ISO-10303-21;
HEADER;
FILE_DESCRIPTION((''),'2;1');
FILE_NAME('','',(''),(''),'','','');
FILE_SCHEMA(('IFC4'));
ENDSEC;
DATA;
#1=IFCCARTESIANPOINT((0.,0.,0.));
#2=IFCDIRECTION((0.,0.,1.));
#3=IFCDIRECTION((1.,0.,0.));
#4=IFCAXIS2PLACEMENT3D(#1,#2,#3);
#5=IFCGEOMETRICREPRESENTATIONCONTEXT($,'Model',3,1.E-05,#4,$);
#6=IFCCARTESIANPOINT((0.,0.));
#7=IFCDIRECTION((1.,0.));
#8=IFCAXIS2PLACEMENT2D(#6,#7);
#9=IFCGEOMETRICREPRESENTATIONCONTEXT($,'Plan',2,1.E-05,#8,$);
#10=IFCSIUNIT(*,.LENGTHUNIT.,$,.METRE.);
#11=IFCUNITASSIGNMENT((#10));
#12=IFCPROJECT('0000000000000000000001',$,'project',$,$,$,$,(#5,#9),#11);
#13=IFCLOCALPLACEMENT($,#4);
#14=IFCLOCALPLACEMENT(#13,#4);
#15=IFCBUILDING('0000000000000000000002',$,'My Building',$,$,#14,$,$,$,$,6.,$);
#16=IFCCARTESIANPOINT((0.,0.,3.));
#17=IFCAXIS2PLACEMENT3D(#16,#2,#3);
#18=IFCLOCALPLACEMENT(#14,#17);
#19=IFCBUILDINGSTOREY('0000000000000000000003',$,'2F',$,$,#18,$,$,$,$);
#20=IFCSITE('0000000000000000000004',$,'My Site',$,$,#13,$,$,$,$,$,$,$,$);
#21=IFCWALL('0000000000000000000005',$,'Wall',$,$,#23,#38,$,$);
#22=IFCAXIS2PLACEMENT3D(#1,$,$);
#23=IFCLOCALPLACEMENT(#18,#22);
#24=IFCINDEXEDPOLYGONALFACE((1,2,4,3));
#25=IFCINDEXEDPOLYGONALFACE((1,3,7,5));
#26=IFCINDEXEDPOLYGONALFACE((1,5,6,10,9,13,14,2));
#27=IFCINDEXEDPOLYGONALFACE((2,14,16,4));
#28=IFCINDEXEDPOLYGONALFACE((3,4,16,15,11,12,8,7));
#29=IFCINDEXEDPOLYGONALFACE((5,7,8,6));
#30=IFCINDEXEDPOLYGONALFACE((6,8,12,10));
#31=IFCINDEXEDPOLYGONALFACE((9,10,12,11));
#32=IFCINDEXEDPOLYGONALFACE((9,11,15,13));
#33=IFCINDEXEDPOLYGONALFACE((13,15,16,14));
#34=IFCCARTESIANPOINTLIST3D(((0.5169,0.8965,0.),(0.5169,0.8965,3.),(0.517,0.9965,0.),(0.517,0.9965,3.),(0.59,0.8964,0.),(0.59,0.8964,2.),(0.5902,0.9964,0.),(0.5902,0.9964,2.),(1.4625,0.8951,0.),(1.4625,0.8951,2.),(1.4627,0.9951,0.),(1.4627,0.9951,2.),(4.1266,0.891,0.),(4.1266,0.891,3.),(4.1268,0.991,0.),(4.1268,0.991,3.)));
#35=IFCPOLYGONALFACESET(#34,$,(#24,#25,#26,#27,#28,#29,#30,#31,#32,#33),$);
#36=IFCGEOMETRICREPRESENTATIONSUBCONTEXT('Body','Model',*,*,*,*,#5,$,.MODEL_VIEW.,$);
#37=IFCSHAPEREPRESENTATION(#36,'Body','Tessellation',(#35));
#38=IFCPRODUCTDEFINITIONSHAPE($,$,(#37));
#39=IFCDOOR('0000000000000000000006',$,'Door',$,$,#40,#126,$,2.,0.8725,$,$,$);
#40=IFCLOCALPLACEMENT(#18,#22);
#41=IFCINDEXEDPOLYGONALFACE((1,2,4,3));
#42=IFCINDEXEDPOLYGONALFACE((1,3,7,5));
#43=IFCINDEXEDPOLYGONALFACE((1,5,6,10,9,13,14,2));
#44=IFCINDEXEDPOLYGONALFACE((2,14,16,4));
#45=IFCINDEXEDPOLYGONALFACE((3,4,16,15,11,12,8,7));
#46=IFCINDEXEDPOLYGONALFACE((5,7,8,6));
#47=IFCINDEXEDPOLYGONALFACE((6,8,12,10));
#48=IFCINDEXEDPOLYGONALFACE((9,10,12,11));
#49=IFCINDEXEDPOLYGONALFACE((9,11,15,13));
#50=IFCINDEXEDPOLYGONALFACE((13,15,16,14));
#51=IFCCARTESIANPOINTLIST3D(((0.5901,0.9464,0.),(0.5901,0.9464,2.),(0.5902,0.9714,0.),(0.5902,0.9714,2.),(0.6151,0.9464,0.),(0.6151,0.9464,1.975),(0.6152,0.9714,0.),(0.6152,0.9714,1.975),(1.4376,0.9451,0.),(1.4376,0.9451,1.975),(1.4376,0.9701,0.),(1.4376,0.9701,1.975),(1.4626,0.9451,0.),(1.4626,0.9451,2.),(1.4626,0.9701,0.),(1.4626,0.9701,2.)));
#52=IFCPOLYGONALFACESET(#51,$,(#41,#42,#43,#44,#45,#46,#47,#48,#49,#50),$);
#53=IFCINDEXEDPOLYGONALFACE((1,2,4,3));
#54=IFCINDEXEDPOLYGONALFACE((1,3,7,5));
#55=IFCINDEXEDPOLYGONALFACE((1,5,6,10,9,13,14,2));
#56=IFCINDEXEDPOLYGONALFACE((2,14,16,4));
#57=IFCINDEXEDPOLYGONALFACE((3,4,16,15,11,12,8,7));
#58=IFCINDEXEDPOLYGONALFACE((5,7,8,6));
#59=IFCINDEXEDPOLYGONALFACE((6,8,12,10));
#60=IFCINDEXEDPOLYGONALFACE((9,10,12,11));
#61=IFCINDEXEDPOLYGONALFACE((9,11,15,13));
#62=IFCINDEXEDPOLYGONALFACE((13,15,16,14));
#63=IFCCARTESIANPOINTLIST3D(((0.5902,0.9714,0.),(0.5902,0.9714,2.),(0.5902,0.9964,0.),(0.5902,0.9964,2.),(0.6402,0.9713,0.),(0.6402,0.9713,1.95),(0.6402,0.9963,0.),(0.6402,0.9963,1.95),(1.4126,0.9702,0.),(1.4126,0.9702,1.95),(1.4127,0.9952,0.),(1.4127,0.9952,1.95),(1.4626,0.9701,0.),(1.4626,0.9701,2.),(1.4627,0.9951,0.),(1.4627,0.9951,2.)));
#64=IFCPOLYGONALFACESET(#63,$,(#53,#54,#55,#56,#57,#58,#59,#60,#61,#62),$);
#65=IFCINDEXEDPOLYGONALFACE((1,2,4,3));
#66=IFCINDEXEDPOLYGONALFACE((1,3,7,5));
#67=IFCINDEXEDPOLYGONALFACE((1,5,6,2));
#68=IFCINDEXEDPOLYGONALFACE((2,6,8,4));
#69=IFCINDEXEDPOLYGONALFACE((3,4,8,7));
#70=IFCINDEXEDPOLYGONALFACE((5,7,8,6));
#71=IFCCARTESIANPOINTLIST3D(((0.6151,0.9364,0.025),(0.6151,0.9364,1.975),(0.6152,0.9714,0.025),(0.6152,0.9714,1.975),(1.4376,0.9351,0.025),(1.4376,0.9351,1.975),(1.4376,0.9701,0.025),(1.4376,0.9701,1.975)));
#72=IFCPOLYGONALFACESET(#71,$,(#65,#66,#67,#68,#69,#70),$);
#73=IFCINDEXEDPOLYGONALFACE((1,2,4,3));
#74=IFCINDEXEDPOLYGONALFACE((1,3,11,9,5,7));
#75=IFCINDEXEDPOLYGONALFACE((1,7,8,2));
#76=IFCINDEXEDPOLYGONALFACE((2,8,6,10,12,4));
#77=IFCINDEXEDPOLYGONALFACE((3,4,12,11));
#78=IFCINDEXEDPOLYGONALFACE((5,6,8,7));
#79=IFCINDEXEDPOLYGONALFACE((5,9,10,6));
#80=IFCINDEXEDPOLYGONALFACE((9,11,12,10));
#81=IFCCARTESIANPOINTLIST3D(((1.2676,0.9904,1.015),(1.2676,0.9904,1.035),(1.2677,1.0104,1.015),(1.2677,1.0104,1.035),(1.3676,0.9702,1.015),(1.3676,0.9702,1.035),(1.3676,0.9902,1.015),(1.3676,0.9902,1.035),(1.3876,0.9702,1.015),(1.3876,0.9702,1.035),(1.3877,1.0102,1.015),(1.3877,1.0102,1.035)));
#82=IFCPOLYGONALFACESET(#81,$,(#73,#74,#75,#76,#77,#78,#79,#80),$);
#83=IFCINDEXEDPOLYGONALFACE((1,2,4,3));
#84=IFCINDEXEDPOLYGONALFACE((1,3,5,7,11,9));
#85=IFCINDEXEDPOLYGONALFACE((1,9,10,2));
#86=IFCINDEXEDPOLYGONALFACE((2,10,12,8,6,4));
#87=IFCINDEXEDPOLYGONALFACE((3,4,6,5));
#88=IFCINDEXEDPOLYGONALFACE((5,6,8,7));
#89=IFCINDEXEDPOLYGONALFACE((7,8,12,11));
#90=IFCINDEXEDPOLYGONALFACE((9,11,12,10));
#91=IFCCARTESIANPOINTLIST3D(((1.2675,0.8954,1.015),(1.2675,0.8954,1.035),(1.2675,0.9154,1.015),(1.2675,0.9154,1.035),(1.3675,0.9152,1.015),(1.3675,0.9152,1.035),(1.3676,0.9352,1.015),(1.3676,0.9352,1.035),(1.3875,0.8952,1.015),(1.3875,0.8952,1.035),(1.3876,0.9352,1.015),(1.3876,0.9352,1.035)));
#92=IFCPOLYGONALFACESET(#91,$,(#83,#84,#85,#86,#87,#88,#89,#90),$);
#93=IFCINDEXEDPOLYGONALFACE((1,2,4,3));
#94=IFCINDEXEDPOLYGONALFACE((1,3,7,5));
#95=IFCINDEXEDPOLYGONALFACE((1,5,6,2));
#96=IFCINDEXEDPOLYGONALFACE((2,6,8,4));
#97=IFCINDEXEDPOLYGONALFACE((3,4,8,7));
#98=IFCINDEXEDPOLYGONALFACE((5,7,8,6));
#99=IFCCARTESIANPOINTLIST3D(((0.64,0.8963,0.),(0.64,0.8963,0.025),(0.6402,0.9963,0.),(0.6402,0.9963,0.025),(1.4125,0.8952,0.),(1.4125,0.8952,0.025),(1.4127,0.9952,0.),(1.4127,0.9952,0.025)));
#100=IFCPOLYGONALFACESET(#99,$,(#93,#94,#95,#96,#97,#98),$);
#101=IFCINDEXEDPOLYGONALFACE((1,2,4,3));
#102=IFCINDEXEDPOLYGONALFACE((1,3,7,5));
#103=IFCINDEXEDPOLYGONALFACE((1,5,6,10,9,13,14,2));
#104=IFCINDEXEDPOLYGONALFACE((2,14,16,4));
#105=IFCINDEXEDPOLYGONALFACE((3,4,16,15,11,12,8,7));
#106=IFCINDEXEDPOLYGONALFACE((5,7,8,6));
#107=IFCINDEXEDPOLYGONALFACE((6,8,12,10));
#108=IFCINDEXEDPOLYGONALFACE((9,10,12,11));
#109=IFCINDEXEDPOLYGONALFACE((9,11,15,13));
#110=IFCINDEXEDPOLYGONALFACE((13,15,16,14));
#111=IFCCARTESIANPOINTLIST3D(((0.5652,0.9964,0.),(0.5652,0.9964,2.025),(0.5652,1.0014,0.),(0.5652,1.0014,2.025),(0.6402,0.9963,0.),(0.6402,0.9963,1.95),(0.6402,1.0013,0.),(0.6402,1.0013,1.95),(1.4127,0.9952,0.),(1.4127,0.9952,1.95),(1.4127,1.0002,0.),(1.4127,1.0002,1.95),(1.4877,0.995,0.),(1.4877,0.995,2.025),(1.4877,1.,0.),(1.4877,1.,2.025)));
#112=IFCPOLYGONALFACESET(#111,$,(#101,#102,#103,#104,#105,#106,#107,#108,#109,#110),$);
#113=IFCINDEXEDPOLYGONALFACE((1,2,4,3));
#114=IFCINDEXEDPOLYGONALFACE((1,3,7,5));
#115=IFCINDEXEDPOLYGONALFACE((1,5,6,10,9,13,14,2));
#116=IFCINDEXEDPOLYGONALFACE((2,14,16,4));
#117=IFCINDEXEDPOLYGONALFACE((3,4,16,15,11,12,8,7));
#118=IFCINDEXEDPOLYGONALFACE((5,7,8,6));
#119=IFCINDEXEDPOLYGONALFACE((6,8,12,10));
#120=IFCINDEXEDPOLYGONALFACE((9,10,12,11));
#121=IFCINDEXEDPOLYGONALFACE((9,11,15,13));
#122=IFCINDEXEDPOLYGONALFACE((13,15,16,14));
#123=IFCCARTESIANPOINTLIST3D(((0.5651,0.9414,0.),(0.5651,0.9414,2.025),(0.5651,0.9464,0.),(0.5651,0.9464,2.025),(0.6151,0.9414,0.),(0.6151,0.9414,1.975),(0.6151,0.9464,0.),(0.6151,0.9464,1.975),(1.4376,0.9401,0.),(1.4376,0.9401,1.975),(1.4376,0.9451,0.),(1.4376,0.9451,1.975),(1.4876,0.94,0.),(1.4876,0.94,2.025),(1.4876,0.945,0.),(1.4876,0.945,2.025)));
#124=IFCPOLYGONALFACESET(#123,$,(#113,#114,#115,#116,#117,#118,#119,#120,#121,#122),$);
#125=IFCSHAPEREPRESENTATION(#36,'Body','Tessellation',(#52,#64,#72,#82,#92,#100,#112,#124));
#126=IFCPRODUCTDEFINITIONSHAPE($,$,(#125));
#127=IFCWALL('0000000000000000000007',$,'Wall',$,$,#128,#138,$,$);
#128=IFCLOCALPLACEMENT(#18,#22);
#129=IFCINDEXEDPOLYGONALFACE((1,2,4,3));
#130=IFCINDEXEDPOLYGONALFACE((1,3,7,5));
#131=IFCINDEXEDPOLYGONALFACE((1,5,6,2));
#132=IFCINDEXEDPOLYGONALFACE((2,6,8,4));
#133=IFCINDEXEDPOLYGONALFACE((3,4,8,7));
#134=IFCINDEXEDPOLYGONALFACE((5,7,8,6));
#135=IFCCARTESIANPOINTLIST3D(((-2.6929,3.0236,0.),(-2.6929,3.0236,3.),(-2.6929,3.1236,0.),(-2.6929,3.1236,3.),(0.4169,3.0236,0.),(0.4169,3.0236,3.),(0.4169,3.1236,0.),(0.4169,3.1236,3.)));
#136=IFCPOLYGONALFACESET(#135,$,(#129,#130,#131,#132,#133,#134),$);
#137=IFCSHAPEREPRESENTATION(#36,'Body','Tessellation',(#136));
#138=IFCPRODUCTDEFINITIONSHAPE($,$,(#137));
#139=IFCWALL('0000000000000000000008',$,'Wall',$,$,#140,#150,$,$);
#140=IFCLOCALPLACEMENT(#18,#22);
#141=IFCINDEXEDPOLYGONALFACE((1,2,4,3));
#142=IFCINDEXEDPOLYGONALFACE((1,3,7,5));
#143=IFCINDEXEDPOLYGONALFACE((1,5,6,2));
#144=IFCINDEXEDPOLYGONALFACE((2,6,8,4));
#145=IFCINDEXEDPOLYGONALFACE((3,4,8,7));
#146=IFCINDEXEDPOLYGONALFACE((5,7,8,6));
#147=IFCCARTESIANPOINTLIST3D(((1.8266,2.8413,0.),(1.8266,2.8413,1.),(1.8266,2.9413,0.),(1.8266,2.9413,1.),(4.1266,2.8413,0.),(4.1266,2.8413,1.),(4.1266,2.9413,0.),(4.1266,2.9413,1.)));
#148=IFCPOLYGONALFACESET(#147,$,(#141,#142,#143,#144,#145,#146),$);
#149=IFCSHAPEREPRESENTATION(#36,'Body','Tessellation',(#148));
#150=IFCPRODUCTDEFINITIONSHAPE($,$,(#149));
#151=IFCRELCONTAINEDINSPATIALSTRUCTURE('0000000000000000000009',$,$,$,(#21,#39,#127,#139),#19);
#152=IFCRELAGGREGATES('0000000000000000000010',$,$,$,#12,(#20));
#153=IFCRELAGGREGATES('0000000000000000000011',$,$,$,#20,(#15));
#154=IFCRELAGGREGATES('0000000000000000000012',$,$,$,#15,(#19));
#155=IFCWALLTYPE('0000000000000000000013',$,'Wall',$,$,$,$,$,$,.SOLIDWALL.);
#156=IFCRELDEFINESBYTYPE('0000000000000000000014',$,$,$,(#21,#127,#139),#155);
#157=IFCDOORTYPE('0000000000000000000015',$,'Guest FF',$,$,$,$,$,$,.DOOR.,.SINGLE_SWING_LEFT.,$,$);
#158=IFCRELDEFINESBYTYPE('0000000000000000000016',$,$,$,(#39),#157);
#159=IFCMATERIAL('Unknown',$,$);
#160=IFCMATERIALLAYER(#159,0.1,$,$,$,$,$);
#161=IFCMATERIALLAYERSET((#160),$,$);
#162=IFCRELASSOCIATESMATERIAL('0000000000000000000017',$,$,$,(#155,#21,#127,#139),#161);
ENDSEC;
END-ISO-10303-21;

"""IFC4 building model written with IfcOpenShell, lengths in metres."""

from ifc_helpers import new_model, entity, si_unit, frame, origin_with_axes, origin_2d_with_axis, place, context, subcontext, project, spatial, line, indexed_curve, outline, extrude, shape, source, transform, mapped, material, layer, layer_set, layer_usage, type_object, type_shapes, element, fill, save


model = new_model("IFC4")

# Units and contexts
model_context = context("Model", 3, precision=1e-05, world=origin_with_axes())
plan_context = context("Plan", 2, precision=1e-05, world=origin_2d_with_axis())
body_context_1 = subcontext(model_context, "Body", "Model", "MODEL_VIEW")
body_context_2 = subcontext(plan_context, "Body", "Plan", "PLAN_VIEW")
ifc_project = project(units=[si_unit("LENGTHUNIT", "METRE")], contexts=[model_context, plan_context])

# Site, building, storey
site_placement = place(None, origin_with_axes())
site = spatial("IfcSite", under=ifc_project, at=site_placement, Name="My Site")
building_placement = place(site_placement, origin_with_axes())
building = spatial("IfcBuilding", under=site, at=building_placement, Name="My Building", ElevationOfTerrain=6.0)
storey_placement = place(building_placement, frame((0.0, 0.0, 3.0), z_axis=(0.0, 0.0, 1.0), x_axis=(1.0, 0.0, 0.0)))
storey = spatial("IfcBuildingStorey", under=building, at=storey_placement, Name="2F")

# Shared definitions
ifc_material = material(Name="Unknown")

# Shared definitions
ifc_layer_1 = layer(ifc_material, 0.1)
ifc_layer_set_1 = layer_set([ifc_layer_1])
wall_type = type_object("IfcWallType", Name="Wall", PredefinedType="SOLIDWALL", material=ifc_layer_set_1)

# Shared definitions
shared_shape_1 = source(origin_with_axes(), body_context_1, "Body", "SweptSolid", [
    extrude(outline(indexed_curve([(0.0, 0.0), (0.8725, 0.0), (0.8725, 2.0), (0.0, 2.0)], segments=[line(1, 2, 3, 4, 1)])), frame((0.0, -0.6, 0.0), z_axis=(0.0, -1.0, 0.0), x_axis=(1.0, 0.0, 0.0)), (0.0, 0.0, -1.0), 1.2),
])
door_type_1 = type_object("IfcDoorType", Name="Guest FF", OperationType="SINGLE_SWING_LEFT", PredefinedType="DOOR")
shared_shape_2 = source(origin_with_axes(), body_context_1, "Body", "SweptSolid", [
    extrude(outline(indexed_curve([(0.0, 0.0), (0.0, 2.0), (0.8725, 2.0), (0.8725, 0.0), (0.8475, 0.0), (0.8475, 1.975), (0.025, 1.975), (0.025, 0.0)], segments=[line(1, 2, 3, 4, 5, 6, 7, 8, 1)])), frame((0.0, 0.025, 0.0), z_axis=(0.0, -1.0, 0.0), x_axis=(1.0, 0.0, 0.0)), (0.0, 0.0, -1.0), 0.025),
    extrude(outline(indexed_curve([(0.0, 0.0), (0.0, 2.0), (0.8725, 2.0), (0.8725, 0.0), (0.8225, 0.0), (0.8225, 1.95), (0.05, 1.95), (0.05, 0.0)], segments=[line(1, 2, 3, 4, 5, 6, 7, 8, 1)])), frame((0.0, 0.0, 0.0), z_axis=(0.0, -1.0, 0.0), x_axis=(1.0, 0.0, 0.0)), (0.0, 0.0, -1.0), 0.025),
    extrude(outline(indexed_curve([(0.0, 0.0), (0.8225, 0.0), (0.8225, 0.035), (0.0, 0.035)], segments=[line(1, 2, 3, 4, 1)])), frame((0.025, 0.025, 0.025), z_axis=(0.0, 0.0, 1.0), x_axis=(1.0, 0.0, 0.0)), (0.0, 0.0, 1.0), 1.95),
    extrude(outline(indexed_curve([(0.0, 0.0), (0.0, -0.04), (0.12, -0.04), (0.12, -0.02), (0.02, -0.02), (0.02, 0.0)], segments=[line(1, 2, 3, 4, 5, 6, 1)])), frame((0.075, 0.025, 1.015), z_axis=(0.0, 0.0, 1.0), x_axis=(1.0, 0.0, 0.0)), (0.0, 0.0, 1.0), 0.02),
    extrude(outline(indexed_curve([(0.0, 0.0), (0.0, 0.04), (0.12, 0.04), (0.12, 0.02), (0.02, 0.02), (0.02, 0.0)], segments=[line(1, 2, 3, 4, 5, 6, 1)])), frame((0.075, 0.06, 1.015), z_axis=(0.0, 0.0, 1.0), x_axis=(1.0, 0.0, 0.0)), (0.0, 0.0, 1.0), 0.02),
    extrude(outline(indexed_curve([(0.0, 0.0), (0.7725, 0.0), (0.7725, 0.1), (0.0, 0.1)], segments=[line(1, 2, 3, 4, 1)])), frame((0.05, 0.0, 0.0), z_axis=(0.0, 0.0, 1.0), x_axis=(1.0, 0.0, 0.0)), (0.0, 0.0, 1.0), 0.025),
    extrude(outline(indexed_curve([(0.0, 0.0), (0.0, 2.025), (0.9225, 2.025), (0.9225, 0.0), (0.8475, 0.0), (0.8475, 1.95), (0.075, 1.95), (0.075, 0.0)], segments=[line(1, 2, 3, 4, 5, 6, 7, 8, 1)])), frame((-0.025, -0.005, 0.0), z_axis=(0.0, -1.0, 0.0), x_axis=(1.0, 0.0, 0.0)), (0.0, 0.0, -1.0), 0.005),
    extrude(outline(indexed_curve([(0.0, 0.0), (0.0, 2.025), (0.9225, 2.025), (0.9225, 0.0), (0.8725, 0.0), (0.8725, 1.975), (0.05, 1.975), (0.05, 0.0)], segments=[line(1, 2, 3, 4, 5, 6, 7, 8, 1)])), frame((-0.025, 0.05, 0.0), z_axis=(0.0, -1.0, 0.0), x_axis=(1.0, 0.0, 0.0)), (0.0, 0.0, -1.0), 0.005),
])
shared_shape_3 = source(origin_with_axes(), body_context_2, "Body", "Curve2D", [
    entity("IfcIndexedPolyCurve", entity("IfcCartesianPointList2D", [[0.0, 0.0], [0.0, 0.05], [0.025, 0.05], [0.025, 0.025], [0.05, 0.025], [0.05, 0.0]]), [entity("IfcLineIndex", [1, 2, 3, 4, 5, 6, 1])]),
    entity("IfcIndexedPolyCurve", entity("IfcCartesianPointList2D", [[0.8725, 0.0], [0.8725, 0.05], [0.8475, 0.05], [0.8475, 0.025], [0.8225, 0.025], [0.8225, 0.0]]), [entity("IfcLineIndex", [1, 2, 3, 4, 5, 6, 1])]),
    entity("IfcTrimmedCurve", entity("IfcEllipse", entity("IfcAxis2Placement2D", entity("IfcCartesianPoint", [0.8125, 0.05]), entity("IfcDirection", [1.0, 0.0])), 0.7875, 0.8225), [entity("IfcCartesianPoint", [0.8125, 0.8725])], [entity("IfcCartesianPoint", [0.025, 0.05])], True, "CARTESIAN"),
    entity("IfcIndexedPolyCurve", entity("IfcCartesianPointList2D", [[0.8475, 0.05], [0.8125, 0.05], [0.8125, 0.8725], [0.8475, 0.8725]]), [entity("IfcLineIndex", [1, 2, 3, 4, 1])]),
])
type_shapes(door_type_1, [shared_shape_2, shared_shape_3])

# Wall, opening, door
ifc_layer_usage_1 = layer_usage(ifc_layer_set_1, "AXIS2", "POSITIVE", 0.0)
wall_1_placement = place(storey_placement, frame((0.5169, 0.8965, 0.0), z_axis=(0.0, 0.0, 1.0), x_axis=(0.999999, -0.001517, 0.0)))
wall_1 = element("IfcWall", 1, at=wall_1_placement, inside=storey, type_object=wall_type, material=ifc_layer_usage_1, Name="Wall", context=body_context_1, shape_type="SweptSolid", body=[
    extrude(outline(indexed_curve([(0.0, 0.0), (0.0, 0.1), (3.6097, 0.1), (3.6097, 0.0)], segments=[line(1, 2, 3, 4, 1)])), origin_with_axes(), (0.0, 0.0, 1.0), 3.0),
])
opening_1_placement = place(wall_1_placement, frame((0.9456, 0.1, 0.0), z_axis=(0.0, 0.0, 1.0), x_axis=(-1.0, 0.0, 0.0)))
opening_1 = element("IfcOpeningElement", 2, at=opening_1_placement, cuts=wall_1, PredefinedType="OPENING", context=body_context_1, shape_type="MappedRepresentation", body=[
    mapped(shared_shape_1, transform((0.0, 0.0, 0.0), x_axis=(1.0, 0.0, 0.0), y_axis=(0.0, 1.0, 0.0), z_axis=(0.0, 0.0, 1.0), scale=1.0)),
])
door_1_placement = place(opening_1_placement, frame((0.0, 0.0, 0.0), z_axis=(0.0, 0.0, 1.0), x_axis=(1.0, 0.0, 0.0)))
door_1 = element("IfcDoor", 3, at=door_1_placement, inside=storey, type_object=door_type_1, Name="Door", OverallHeight=2.0, OverallWidth=0.8725, shapes=[
    shape(body_context_1, "Body", "MappedRepresentation", [mapped(shared_shape_2, transform((0.0, 0.0, 0.0), x_axis=(1.0, 0.0, 0.0), y_axis=(0.0, 1.0, 0.0), z_axis=(0.0, 0.0, 1.0), scale=1.0))]),
    shape(body_context_2, "Body", "MappedRepresentation", [mapped(shared_shape_3, transform((0.0, 0.0, 0.0), x_axis=(1.0, 0.0, 0.0), y_axis=(0.0, 1.0, 0.0), z_axis=(0.0, 0.0, 1.0), scale=1.0))]),
])
fill(opening_1, door_1)

# Walls
ifc_layer_usage_2 = layer_usage(ifc_layer_set_1, "AXIS2", "POSITIVE", 0.0)
wall_2_placement = place(storey_placement, frame((0.4169, 3.1236, 0.0), z_axis=(0.0, 0.0, 1.0), x_axis=(-1.0, 0.0, 0.0)))
element("IfcWall", 4, at=wall_2_placement, inside=storey, type_object=wall_type, material=ifc_layer_usage_2, Name="Wall", context=body_context_1, shape_type="SweptSolid", body=[
    extrude(outline(indexed_curve([(0.0, 0.0), (0.0, 0.1), (3.1098, 0.1), (3.1098, 0.0)], segments=[line(1, 2, 3, 4, 1)])), origin_with_axes(), (0.0, 0.0, 1.0), 3.0),
])
ifc_layer_usage_3 = layer_usage(ifc_layer_set_1, "AXIS2", "POSITIVE", 0.0)
wall_3_placement = place(storey_placement, frame((4.1266, 2.9413, 0.0), z_axis=(0.0, 0.0, 1.0), x_axis=(-1.0, 0.0, 0.0)))
element("IfcWall", 5, at=wall_3_placement, inside=storey, type_object=wall_type, material=ifc_layer_usage_3, Name="Wall", context=body_context_1, shape_type="SweptSolid", body=[
    extrude(outline(indexed_curve([(0.0, 0.0), (0.0, 0.1), (2.3, 0.1), (2.3, 0.0)], segments=[line(1, 2, 3, 4, 1)])), origin_with_axes(), (0.0, 0.0, 1.0), 1.0),
])

save(model, "model.ifc")
